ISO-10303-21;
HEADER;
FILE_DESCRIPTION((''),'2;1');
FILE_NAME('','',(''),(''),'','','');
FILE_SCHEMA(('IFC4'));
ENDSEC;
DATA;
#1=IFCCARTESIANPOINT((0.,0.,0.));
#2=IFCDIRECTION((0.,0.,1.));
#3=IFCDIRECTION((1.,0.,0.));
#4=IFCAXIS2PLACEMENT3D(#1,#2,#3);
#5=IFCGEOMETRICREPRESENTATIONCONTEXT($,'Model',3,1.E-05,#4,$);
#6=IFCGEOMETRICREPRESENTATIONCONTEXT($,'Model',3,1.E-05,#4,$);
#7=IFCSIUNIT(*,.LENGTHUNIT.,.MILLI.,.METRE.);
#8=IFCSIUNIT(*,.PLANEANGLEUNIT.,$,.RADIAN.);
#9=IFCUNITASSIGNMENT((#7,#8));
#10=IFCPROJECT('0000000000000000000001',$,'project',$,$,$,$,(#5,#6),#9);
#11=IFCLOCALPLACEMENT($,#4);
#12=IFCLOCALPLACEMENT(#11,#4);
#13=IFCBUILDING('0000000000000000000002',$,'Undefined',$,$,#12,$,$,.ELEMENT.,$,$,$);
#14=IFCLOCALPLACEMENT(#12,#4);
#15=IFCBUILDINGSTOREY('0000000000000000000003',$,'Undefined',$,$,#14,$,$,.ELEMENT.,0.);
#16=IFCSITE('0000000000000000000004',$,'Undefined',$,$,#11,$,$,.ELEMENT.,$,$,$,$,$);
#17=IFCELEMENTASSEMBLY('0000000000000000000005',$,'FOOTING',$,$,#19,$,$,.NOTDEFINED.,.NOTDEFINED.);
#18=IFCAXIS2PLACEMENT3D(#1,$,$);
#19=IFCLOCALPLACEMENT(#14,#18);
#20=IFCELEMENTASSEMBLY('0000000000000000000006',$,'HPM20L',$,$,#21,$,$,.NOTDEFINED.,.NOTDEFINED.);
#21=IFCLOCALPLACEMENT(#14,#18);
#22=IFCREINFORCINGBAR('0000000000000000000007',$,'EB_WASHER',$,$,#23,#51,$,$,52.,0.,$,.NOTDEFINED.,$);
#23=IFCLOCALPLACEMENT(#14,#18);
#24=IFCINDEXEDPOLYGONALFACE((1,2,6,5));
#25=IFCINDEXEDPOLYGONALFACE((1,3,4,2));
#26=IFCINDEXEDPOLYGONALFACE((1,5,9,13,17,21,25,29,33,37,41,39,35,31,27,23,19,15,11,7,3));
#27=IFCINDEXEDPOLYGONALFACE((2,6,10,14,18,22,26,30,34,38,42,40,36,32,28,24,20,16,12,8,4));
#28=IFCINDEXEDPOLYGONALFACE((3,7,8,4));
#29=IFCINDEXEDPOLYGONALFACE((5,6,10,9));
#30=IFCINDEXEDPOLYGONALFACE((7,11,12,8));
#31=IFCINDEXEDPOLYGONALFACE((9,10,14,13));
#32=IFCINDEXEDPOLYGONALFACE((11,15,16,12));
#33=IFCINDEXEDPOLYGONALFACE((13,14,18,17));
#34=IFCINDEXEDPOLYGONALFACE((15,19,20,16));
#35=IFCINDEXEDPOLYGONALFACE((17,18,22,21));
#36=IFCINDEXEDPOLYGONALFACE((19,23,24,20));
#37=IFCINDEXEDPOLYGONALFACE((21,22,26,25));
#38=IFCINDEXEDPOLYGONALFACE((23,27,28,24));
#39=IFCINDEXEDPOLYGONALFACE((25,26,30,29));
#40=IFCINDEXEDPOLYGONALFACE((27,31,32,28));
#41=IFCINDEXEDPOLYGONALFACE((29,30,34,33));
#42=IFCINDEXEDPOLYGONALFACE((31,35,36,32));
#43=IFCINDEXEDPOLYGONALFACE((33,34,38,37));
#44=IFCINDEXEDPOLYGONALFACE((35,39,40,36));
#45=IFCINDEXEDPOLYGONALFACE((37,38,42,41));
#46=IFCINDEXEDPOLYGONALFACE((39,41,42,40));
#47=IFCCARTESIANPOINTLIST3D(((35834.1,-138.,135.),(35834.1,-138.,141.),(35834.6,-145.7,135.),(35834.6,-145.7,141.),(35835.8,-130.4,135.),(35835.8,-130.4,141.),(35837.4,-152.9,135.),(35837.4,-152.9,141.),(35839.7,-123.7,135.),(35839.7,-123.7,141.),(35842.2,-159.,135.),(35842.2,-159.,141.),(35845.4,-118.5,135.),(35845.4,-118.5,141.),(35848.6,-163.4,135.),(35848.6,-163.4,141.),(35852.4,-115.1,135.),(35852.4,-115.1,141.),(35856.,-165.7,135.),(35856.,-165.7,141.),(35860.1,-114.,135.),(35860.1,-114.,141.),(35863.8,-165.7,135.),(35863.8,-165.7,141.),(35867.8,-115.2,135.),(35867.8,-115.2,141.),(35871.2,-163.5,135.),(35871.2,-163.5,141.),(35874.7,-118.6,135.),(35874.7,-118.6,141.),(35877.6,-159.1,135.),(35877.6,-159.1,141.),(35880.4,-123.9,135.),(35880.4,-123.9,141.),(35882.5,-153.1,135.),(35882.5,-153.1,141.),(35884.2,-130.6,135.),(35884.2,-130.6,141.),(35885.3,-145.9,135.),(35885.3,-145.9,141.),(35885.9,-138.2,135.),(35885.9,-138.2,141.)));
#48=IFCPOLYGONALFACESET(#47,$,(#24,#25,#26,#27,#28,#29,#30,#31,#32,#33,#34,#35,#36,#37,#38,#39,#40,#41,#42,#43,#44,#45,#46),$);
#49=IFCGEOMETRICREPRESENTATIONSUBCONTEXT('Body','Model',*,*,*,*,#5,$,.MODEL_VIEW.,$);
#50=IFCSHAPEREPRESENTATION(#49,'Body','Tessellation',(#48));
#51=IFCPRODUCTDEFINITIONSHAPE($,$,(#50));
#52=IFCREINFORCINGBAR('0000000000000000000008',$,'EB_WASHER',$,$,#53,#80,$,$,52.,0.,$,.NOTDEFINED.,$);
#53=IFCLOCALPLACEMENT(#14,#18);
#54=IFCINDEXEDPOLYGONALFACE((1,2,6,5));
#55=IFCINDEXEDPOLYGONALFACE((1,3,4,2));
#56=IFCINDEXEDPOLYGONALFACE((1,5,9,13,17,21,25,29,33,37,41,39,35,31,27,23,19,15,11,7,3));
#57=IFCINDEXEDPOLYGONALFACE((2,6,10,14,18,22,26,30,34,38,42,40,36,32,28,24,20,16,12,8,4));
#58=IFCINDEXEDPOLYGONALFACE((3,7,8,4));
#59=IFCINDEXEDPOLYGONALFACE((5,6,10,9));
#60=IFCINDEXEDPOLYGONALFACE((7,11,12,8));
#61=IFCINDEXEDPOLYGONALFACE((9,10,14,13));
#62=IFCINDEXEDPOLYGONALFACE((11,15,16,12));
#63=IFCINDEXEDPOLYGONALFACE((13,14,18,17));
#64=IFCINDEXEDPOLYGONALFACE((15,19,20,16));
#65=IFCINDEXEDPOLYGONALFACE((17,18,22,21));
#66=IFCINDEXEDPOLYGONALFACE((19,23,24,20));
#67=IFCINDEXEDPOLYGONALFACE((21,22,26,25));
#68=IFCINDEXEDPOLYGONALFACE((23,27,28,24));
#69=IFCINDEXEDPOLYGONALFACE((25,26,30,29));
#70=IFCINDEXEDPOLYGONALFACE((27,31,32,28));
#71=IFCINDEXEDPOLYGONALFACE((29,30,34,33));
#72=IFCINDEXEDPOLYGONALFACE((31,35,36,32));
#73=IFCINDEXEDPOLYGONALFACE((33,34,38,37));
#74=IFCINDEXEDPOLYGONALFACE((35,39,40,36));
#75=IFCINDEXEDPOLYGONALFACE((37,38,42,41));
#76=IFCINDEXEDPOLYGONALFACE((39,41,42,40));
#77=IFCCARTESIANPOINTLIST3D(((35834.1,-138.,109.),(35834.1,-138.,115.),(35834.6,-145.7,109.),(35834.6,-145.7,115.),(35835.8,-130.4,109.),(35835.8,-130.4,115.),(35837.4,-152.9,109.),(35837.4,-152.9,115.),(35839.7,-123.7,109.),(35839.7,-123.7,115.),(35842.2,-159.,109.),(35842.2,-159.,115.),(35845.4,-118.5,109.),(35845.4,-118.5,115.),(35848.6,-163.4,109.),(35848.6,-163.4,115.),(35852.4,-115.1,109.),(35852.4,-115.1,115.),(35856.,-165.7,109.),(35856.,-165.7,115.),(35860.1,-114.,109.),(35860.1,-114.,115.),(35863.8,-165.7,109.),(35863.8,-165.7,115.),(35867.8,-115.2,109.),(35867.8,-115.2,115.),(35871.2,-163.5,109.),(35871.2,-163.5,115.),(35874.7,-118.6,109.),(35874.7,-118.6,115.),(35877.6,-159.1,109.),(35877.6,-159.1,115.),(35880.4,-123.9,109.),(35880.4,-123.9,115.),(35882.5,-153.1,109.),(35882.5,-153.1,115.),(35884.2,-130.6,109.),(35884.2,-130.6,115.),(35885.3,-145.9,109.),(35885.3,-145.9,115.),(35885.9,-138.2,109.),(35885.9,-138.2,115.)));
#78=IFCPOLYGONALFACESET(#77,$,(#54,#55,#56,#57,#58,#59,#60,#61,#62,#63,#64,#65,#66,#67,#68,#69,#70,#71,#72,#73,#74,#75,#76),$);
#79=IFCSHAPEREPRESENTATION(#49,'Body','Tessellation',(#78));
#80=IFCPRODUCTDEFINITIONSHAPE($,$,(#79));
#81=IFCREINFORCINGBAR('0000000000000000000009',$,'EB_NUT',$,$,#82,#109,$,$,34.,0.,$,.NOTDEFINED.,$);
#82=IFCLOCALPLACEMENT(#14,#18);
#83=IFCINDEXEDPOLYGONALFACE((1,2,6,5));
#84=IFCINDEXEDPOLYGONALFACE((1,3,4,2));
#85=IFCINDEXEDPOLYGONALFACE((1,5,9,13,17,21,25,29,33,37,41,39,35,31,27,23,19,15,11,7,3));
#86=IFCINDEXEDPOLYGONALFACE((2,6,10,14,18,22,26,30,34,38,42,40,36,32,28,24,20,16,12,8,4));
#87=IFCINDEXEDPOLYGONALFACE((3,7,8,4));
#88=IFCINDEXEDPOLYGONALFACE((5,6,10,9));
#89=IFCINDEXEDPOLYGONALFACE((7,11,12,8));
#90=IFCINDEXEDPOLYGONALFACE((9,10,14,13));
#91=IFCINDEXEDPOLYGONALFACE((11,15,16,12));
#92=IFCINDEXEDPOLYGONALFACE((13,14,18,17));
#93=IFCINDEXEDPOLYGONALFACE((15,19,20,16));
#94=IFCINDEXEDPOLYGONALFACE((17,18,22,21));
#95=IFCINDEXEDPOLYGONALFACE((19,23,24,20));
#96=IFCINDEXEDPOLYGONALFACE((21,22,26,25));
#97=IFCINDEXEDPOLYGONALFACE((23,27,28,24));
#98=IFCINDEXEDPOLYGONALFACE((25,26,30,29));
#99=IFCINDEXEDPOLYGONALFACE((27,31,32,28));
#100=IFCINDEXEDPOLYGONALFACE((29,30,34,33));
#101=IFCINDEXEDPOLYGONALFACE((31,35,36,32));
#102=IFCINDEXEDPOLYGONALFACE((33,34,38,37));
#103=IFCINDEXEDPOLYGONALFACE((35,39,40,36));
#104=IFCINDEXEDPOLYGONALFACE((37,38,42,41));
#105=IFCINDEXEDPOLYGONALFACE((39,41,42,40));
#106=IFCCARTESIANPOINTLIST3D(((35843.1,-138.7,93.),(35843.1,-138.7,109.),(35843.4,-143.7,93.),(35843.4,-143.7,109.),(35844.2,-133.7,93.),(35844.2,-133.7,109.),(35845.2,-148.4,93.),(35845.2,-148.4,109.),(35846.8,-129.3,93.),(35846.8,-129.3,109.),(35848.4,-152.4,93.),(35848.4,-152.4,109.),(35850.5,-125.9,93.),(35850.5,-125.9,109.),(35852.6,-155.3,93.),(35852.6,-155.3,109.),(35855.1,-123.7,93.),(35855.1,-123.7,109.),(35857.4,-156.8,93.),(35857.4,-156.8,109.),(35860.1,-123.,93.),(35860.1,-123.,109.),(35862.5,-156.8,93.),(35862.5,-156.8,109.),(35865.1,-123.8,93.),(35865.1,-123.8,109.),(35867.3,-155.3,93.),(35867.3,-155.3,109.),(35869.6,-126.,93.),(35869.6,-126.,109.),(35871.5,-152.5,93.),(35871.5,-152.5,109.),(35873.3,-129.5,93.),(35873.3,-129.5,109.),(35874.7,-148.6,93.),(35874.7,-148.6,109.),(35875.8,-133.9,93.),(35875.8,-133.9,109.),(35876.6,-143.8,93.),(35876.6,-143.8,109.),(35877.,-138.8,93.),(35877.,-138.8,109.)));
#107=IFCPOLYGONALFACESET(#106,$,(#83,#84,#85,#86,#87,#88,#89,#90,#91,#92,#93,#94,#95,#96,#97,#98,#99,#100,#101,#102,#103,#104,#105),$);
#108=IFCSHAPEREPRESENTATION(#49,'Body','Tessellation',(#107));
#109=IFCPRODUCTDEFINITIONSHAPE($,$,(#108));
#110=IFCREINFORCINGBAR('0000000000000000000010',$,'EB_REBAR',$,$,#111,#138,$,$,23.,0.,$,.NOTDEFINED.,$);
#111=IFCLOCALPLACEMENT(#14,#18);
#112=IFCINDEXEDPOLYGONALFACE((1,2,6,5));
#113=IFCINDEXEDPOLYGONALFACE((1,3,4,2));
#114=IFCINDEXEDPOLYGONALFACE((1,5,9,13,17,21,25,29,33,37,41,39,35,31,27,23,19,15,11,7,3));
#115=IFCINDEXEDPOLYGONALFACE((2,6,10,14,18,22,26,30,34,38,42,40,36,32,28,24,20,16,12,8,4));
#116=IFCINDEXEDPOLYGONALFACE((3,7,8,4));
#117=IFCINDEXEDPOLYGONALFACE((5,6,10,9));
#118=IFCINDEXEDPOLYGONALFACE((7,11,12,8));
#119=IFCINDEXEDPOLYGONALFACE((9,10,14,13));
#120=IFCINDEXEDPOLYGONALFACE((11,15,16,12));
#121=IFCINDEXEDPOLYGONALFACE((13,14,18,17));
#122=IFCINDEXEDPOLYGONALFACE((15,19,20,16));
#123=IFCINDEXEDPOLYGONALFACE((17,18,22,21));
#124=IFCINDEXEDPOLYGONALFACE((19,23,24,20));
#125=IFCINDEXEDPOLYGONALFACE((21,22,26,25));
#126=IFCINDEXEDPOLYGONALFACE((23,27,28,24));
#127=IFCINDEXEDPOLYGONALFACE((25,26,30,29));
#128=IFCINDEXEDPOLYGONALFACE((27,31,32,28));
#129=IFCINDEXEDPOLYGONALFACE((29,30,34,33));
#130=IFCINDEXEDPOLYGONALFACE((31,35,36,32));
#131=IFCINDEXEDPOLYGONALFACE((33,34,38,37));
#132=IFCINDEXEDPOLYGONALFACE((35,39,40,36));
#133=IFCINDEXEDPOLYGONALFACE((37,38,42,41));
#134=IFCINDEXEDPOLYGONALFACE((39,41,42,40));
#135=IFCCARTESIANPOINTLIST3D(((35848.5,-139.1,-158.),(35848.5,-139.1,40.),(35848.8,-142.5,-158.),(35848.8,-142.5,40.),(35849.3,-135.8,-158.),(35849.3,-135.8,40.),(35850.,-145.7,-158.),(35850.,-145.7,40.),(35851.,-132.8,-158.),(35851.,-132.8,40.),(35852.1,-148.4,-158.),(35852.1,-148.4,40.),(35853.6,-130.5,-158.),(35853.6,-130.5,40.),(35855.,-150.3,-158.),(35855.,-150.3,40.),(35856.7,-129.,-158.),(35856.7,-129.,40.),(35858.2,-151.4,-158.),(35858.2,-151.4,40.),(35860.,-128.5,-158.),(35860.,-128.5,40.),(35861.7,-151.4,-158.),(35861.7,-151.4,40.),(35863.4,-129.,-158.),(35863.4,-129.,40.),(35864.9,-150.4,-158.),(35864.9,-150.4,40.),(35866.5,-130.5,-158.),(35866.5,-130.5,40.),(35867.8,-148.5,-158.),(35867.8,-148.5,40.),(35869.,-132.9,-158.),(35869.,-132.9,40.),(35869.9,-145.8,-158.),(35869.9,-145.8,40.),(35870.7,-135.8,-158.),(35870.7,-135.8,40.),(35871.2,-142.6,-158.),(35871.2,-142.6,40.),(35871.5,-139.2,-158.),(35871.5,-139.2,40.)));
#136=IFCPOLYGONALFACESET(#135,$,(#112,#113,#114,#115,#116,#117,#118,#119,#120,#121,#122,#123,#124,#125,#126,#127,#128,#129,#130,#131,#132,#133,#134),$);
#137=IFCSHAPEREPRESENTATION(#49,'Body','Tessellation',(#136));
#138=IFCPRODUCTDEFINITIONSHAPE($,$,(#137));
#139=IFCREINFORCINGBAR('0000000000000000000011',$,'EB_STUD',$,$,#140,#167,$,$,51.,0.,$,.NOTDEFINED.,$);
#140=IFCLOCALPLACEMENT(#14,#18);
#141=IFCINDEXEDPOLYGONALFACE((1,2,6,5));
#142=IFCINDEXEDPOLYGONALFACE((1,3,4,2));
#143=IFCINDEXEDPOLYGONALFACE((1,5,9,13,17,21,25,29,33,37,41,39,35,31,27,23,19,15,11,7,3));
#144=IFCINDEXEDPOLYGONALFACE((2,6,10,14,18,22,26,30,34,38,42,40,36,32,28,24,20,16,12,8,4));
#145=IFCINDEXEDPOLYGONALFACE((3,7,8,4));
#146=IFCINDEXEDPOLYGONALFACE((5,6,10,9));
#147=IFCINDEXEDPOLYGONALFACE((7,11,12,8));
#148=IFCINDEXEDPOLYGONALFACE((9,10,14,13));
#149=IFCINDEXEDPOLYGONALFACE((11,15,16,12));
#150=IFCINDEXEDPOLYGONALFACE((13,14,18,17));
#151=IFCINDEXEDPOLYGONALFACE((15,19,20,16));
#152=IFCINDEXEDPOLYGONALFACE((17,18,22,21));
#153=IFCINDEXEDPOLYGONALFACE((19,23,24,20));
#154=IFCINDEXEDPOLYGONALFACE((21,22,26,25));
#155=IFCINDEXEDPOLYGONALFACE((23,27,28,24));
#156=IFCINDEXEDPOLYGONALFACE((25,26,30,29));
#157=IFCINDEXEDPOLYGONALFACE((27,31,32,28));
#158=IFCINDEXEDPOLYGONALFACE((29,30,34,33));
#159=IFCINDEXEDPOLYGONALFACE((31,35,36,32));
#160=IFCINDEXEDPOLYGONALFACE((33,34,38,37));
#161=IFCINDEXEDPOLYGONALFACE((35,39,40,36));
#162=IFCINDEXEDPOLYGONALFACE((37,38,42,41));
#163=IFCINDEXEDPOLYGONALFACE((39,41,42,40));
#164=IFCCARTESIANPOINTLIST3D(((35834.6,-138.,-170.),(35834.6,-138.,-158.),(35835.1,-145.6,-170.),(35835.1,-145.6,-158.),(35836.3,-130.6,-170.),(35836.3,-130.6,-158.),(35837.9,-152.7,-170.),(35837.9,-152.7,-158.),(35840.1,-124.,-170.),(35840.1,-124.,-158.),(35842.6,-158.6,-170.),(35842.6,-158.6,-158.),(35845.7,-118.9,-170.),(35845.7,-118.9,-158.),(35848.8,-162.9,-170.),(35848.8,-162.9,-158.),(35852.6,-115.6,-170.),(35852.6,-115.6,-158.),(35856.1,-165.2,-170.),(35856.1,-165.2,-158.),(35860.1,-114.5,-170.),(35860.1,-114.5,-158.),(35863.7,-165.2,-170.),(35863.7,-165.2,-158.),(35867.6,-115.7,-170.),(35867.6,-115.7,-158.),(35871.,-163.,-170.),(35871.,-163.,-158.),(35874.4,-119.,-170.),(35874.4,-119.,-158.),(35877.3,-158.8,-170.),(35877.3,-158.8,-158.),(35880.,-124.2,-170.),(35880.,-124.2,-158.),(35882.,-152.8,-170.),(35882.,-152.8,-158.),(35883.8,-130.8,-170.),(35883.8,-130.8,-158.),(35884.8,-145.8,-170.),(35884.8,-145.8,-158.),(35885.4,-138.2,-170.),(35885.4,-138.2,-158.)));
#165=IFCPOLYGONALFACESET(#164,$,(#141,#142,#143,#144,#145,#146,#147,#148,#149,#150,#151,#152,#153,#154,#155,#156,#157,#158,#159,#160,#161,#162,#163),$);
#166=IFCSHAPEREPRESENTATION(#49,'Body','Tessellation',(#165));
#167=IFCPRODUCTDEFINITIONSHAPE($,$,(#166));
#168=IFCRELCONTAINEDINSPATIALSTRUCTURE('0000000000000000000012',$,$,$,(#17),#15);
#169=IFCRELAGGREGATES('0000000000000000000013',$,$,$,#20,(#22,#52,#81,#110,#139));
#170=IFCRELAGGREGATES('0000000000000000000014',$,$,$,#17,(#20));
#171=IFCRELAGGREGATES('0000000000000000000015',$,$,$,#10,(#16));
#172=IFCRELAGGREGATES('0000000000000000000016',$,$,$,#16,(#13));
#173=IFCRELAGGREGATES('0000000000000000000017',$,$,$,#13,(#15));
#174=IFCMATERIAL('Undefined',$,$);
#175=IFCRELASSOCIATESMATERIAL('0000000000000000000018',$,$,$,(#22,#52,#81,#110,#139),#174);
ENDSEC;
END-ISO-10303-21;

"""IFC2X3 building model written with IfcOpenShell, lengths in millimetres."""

from ifc_helpers import new_model, entity, si_unit, frame, origin_with_axes, place, context, subcontext, project, spatial, source, transform, mapped, material, element, aggregate, save


model = new_model("IFC2X3")

# Units and contexts
model_context_1 = context("Model", 3, precision=1e-05, world=origin_with_axes())
model_context_2 = context("Model", 3, precision=1e-05, world=origin_with_axes())
body_context = subcontext(model_context_1, "Body", "Model", "MODEL_VIEW")
ifc_project = project(units=[si_unit("LENGTHUNIT", "METRE", prefix="MILLI"), si_unit("PLANEANGLEUNIT", "RADIAN")], contexts=[model_context_1, model_context_2])

# Site, building, storey
site_placement = place(None, origin_with_axes())
site = spatial("IfcSite", under=ifc_project, at=site_placement, Name="Undefined", CompositionType="ELEMENT")
building_placement = place(site_placement, origin_with_axes())
building = spatial("IfcBuilding", under=site, at=building_placement, Name="Undefined", CompositionType="ELEMENT")
storey_placement = place(building_placement, origin_with_axes())
storey = spatial("IfcBuildingStorey", under=building, at=storey_placement, Name="Undefined", CompositionType="ELEMENT", Elevation=0.0)

# Element assembly
assembly_1_placement = place(storey_placement, origin_with_axes())
assembly_1 = element("IfcElementAssembly", 1, at=assembly_1_placement, inside=storey, Name="FOOTING", AssemblyPlace="NOTDEFINED", PredefinedType="NOTDEFINED")

# Shared definitions
ifc_material_1 = material(Name="Undefined")

# Element assembly, reinforcing bars
assembly_2_placement = place(assembly_1_placement, origin_with_axes())
assembly_2 = element("IfcElementAssembly", 2, at=assembly_2_placement, Name="HPM20L", AssemblyPlace="NOTDEFINED", PredefinedType="NOTDEFINED")
shared_shape_1 = source(origin_with_axes(), body_context, "Body", "AdvancedSweptSolid", [
    entity("IfcSweptDiskSolid", entity("IfcTrimmedCurve", entity("IfcLine", entity("IfcCartesianPoint", [0.0, 0.0, 0.0]), entity("IfcVector", entity("IfcDirection", [1.0, 0.0, 0.0]), 1.0)), [entity("IfcParameterValue", 0.0)], [entity("IfcParameterValue", 6.0)], True, "PARAMETER"), 26.0, None, 0.0, 6.0),
])
reinforcing_bar_1_placement = place(assembly_2_placement, frame((35860.0, -140.0, 141.0), z_axis=(0.003904, 0.999992, 0.0), x_axis=(0.0, 0.0, -1.0)))
reinforcing_bar_1 = element("IfcReinforcingBar", 3, at=reinforcing_bar_1_placement, material=ifc_material_1, Name="EB_WASHER", BarRole="NOTDEFINED", CrossSectionArea=0.0, NominalDiameter=52.0, context=body_context, shape_type="MappedRepresentation", body=[
    mapped(shared_shape_1, transform((0.0, 0.0, 0.0))),
])
shared_shape_2 = source(origin_with_axes(), body_context, "Body", "AdvancedSweptSolid", [
    entity("IfcSweptDiskSolid", entity("IfcTrimmedCurve", entity("IfcLine", entity("IfcCartesianPoint", [0.0, 0.0, 0.0]), entity("IfcVector", entity("IfcDirection", [1.0, 0.0, 0.0]), 1.0)), [entity("IfcParameterValue", 0.0)], [entity("IfcParameterValue", 6.0)], True, "PARAMETER"), 26.0, None, 0.0, 6.0),
])
reinforcing_bar_2_placement = place(assembly_2_placement, frame((35860.0, -140.0, 115.0), z_axis=(0.003904, 0.999992, 0.0), x_axis=(0.0, 0.0, -1.0)))
reinforcing_bar_2 = element("IfcReinforcingBar", 4, at=reinforcing_bar_2_placement, material=ifc_material_1, Name="EB_WASHER", BarRole="NOTDEFINED", CrossSectionArea=0.0, NominalDiameter=52.0, context=body_context, shape_type="MappedRepresentation", body=[
    mapped(shared_shape_2, transform((0.0, 0.0, 0.0))),
])
shared_shape_3 = source(origin_with_axes(), body_context, "Body", "AdvancedSweptSolid", [
    entity("IfcSweptDiskSolid", entity("IfcTrimmedCurve", entity("IfcLine", entity("IfcCartesianPoint", [0.0, 0.0, 0.0]), entity("IfcVector", entity("IfcDirection", [1.0, 0.0, 0.0]), 1.0)), [entity("IfcParameterValue", 0.0)], [entity("IfcParameterValue", 16.0)], True, "PARAMETER"), 17.0, None, 0.0, 16.0),
])
reinforcing_bar_3_placement = place(assembly_2_placement, frame((35860.0, -140.0, 109.0), z_axis=(0.003904, 0.999992, 0.0), x_axis=(0.0, 0.0, -1.0)))
reinforcing_bar_3 = element("IfcReinforcingBar", 5, at=reinforcing_bar_3_placement, material=ifc_material_1, Name="EB_NUT", BarRole="NOTDEFINED", CrossSectionArea=0.0, NominalDiameter=34.0, context=body_context, shape_type="MappedRepresentation", body=[
    mapped(shared_shape_3, transform((0.0, 0.0, 0.0))),
])
shared_shape_4 = source(origin_with_axes(), body_context, "Body", "AdvancedSweptSolid", [
    entity("IfcSweptDiskSolid", entity("IfcTrimmedCurve", entity("IfcLine", entity("IfcCartesianPoint", [0.0, 0.0, 0.0]), entity("IfcVector", entity("IfcDirection", [1.0, 0.0, 0.0]), 1.0)), [entity("IfcParameterValue", 0.0)], [entity("IfcParameterValue", 198.0)], True, "PARAMETER"), 11.5, None, 0.0, 198.0),
])
reinforcing_bar_4_placement = place(assembly_2_placement, frame((35860.0, -140.0, 40.0), z_axis=(0.003904, 0.999992, 0.0), x_axis=(0.0, 0.0, -1.0)))
reinforcing_bar_4 = element("IfcReinforcingBar", 6, at=reinforcing_bar_4_placement, material=ifc_material_1, Name="EB_REBAR", BarRole="NOTDEFINED", CrossSectionArea=0.0, NominalDiameter=23.0, context=body_context, shape_type="MappedRepresentation", body=[
    mapped(shared_shape_4, transform((0.0, 0.0, 0.0))),
])
shared_shape_5 = source(origin_with_axes(), body_context, "Body", "AdvancedSweptSolid", [
    entity("IfcSweptDiskSolid", entity("IfcTrimmedCurve", entity("IfcLine", entity("IfcCartesianPoint", [0.0, 0.0, 0.0]), entity("IfcVector", entity("IfcDirection", [1.0, 0.0, 0.0]), 1.0)), [entity("IfcParameterValue", 0.0)], [entity("IfcParameterValue", 12.0)], True, "PARAMETER"), 25.5, None, 0.0, 12.0),
])
reinforcing_bar_5_placement = place(assembly_2_placement, frame((35860.0, -140.0, -158.0), z_axis=(0.003904, 0.999992, 0.0), x_axis=(0.0, 0.0, -1.0)))
reinforcing_bar_5 = element("IfcReinforcingBar", 7, at=reinforcing_bar_5_placement, material=ifc_material_1, Name="EB_STUD", BarRole="NOTDEFINED", CrossSectionArea=0.0, NominalDiameter=51.0, context=body_context, shape_type="MappedRepresentation", body=[
    mapped(shared_shape_5, transform((0.0, 0.0, 0.0))),
])
aggregate(assembly_2, [reinforcing_bar_1, reinforcing_bar_2, reinforcing_bar_3, reinforcing_bar_4, reinforcing_bar_5])

aggregate(assembly_1, [assembly_2])

save(model, "model.ifc")
